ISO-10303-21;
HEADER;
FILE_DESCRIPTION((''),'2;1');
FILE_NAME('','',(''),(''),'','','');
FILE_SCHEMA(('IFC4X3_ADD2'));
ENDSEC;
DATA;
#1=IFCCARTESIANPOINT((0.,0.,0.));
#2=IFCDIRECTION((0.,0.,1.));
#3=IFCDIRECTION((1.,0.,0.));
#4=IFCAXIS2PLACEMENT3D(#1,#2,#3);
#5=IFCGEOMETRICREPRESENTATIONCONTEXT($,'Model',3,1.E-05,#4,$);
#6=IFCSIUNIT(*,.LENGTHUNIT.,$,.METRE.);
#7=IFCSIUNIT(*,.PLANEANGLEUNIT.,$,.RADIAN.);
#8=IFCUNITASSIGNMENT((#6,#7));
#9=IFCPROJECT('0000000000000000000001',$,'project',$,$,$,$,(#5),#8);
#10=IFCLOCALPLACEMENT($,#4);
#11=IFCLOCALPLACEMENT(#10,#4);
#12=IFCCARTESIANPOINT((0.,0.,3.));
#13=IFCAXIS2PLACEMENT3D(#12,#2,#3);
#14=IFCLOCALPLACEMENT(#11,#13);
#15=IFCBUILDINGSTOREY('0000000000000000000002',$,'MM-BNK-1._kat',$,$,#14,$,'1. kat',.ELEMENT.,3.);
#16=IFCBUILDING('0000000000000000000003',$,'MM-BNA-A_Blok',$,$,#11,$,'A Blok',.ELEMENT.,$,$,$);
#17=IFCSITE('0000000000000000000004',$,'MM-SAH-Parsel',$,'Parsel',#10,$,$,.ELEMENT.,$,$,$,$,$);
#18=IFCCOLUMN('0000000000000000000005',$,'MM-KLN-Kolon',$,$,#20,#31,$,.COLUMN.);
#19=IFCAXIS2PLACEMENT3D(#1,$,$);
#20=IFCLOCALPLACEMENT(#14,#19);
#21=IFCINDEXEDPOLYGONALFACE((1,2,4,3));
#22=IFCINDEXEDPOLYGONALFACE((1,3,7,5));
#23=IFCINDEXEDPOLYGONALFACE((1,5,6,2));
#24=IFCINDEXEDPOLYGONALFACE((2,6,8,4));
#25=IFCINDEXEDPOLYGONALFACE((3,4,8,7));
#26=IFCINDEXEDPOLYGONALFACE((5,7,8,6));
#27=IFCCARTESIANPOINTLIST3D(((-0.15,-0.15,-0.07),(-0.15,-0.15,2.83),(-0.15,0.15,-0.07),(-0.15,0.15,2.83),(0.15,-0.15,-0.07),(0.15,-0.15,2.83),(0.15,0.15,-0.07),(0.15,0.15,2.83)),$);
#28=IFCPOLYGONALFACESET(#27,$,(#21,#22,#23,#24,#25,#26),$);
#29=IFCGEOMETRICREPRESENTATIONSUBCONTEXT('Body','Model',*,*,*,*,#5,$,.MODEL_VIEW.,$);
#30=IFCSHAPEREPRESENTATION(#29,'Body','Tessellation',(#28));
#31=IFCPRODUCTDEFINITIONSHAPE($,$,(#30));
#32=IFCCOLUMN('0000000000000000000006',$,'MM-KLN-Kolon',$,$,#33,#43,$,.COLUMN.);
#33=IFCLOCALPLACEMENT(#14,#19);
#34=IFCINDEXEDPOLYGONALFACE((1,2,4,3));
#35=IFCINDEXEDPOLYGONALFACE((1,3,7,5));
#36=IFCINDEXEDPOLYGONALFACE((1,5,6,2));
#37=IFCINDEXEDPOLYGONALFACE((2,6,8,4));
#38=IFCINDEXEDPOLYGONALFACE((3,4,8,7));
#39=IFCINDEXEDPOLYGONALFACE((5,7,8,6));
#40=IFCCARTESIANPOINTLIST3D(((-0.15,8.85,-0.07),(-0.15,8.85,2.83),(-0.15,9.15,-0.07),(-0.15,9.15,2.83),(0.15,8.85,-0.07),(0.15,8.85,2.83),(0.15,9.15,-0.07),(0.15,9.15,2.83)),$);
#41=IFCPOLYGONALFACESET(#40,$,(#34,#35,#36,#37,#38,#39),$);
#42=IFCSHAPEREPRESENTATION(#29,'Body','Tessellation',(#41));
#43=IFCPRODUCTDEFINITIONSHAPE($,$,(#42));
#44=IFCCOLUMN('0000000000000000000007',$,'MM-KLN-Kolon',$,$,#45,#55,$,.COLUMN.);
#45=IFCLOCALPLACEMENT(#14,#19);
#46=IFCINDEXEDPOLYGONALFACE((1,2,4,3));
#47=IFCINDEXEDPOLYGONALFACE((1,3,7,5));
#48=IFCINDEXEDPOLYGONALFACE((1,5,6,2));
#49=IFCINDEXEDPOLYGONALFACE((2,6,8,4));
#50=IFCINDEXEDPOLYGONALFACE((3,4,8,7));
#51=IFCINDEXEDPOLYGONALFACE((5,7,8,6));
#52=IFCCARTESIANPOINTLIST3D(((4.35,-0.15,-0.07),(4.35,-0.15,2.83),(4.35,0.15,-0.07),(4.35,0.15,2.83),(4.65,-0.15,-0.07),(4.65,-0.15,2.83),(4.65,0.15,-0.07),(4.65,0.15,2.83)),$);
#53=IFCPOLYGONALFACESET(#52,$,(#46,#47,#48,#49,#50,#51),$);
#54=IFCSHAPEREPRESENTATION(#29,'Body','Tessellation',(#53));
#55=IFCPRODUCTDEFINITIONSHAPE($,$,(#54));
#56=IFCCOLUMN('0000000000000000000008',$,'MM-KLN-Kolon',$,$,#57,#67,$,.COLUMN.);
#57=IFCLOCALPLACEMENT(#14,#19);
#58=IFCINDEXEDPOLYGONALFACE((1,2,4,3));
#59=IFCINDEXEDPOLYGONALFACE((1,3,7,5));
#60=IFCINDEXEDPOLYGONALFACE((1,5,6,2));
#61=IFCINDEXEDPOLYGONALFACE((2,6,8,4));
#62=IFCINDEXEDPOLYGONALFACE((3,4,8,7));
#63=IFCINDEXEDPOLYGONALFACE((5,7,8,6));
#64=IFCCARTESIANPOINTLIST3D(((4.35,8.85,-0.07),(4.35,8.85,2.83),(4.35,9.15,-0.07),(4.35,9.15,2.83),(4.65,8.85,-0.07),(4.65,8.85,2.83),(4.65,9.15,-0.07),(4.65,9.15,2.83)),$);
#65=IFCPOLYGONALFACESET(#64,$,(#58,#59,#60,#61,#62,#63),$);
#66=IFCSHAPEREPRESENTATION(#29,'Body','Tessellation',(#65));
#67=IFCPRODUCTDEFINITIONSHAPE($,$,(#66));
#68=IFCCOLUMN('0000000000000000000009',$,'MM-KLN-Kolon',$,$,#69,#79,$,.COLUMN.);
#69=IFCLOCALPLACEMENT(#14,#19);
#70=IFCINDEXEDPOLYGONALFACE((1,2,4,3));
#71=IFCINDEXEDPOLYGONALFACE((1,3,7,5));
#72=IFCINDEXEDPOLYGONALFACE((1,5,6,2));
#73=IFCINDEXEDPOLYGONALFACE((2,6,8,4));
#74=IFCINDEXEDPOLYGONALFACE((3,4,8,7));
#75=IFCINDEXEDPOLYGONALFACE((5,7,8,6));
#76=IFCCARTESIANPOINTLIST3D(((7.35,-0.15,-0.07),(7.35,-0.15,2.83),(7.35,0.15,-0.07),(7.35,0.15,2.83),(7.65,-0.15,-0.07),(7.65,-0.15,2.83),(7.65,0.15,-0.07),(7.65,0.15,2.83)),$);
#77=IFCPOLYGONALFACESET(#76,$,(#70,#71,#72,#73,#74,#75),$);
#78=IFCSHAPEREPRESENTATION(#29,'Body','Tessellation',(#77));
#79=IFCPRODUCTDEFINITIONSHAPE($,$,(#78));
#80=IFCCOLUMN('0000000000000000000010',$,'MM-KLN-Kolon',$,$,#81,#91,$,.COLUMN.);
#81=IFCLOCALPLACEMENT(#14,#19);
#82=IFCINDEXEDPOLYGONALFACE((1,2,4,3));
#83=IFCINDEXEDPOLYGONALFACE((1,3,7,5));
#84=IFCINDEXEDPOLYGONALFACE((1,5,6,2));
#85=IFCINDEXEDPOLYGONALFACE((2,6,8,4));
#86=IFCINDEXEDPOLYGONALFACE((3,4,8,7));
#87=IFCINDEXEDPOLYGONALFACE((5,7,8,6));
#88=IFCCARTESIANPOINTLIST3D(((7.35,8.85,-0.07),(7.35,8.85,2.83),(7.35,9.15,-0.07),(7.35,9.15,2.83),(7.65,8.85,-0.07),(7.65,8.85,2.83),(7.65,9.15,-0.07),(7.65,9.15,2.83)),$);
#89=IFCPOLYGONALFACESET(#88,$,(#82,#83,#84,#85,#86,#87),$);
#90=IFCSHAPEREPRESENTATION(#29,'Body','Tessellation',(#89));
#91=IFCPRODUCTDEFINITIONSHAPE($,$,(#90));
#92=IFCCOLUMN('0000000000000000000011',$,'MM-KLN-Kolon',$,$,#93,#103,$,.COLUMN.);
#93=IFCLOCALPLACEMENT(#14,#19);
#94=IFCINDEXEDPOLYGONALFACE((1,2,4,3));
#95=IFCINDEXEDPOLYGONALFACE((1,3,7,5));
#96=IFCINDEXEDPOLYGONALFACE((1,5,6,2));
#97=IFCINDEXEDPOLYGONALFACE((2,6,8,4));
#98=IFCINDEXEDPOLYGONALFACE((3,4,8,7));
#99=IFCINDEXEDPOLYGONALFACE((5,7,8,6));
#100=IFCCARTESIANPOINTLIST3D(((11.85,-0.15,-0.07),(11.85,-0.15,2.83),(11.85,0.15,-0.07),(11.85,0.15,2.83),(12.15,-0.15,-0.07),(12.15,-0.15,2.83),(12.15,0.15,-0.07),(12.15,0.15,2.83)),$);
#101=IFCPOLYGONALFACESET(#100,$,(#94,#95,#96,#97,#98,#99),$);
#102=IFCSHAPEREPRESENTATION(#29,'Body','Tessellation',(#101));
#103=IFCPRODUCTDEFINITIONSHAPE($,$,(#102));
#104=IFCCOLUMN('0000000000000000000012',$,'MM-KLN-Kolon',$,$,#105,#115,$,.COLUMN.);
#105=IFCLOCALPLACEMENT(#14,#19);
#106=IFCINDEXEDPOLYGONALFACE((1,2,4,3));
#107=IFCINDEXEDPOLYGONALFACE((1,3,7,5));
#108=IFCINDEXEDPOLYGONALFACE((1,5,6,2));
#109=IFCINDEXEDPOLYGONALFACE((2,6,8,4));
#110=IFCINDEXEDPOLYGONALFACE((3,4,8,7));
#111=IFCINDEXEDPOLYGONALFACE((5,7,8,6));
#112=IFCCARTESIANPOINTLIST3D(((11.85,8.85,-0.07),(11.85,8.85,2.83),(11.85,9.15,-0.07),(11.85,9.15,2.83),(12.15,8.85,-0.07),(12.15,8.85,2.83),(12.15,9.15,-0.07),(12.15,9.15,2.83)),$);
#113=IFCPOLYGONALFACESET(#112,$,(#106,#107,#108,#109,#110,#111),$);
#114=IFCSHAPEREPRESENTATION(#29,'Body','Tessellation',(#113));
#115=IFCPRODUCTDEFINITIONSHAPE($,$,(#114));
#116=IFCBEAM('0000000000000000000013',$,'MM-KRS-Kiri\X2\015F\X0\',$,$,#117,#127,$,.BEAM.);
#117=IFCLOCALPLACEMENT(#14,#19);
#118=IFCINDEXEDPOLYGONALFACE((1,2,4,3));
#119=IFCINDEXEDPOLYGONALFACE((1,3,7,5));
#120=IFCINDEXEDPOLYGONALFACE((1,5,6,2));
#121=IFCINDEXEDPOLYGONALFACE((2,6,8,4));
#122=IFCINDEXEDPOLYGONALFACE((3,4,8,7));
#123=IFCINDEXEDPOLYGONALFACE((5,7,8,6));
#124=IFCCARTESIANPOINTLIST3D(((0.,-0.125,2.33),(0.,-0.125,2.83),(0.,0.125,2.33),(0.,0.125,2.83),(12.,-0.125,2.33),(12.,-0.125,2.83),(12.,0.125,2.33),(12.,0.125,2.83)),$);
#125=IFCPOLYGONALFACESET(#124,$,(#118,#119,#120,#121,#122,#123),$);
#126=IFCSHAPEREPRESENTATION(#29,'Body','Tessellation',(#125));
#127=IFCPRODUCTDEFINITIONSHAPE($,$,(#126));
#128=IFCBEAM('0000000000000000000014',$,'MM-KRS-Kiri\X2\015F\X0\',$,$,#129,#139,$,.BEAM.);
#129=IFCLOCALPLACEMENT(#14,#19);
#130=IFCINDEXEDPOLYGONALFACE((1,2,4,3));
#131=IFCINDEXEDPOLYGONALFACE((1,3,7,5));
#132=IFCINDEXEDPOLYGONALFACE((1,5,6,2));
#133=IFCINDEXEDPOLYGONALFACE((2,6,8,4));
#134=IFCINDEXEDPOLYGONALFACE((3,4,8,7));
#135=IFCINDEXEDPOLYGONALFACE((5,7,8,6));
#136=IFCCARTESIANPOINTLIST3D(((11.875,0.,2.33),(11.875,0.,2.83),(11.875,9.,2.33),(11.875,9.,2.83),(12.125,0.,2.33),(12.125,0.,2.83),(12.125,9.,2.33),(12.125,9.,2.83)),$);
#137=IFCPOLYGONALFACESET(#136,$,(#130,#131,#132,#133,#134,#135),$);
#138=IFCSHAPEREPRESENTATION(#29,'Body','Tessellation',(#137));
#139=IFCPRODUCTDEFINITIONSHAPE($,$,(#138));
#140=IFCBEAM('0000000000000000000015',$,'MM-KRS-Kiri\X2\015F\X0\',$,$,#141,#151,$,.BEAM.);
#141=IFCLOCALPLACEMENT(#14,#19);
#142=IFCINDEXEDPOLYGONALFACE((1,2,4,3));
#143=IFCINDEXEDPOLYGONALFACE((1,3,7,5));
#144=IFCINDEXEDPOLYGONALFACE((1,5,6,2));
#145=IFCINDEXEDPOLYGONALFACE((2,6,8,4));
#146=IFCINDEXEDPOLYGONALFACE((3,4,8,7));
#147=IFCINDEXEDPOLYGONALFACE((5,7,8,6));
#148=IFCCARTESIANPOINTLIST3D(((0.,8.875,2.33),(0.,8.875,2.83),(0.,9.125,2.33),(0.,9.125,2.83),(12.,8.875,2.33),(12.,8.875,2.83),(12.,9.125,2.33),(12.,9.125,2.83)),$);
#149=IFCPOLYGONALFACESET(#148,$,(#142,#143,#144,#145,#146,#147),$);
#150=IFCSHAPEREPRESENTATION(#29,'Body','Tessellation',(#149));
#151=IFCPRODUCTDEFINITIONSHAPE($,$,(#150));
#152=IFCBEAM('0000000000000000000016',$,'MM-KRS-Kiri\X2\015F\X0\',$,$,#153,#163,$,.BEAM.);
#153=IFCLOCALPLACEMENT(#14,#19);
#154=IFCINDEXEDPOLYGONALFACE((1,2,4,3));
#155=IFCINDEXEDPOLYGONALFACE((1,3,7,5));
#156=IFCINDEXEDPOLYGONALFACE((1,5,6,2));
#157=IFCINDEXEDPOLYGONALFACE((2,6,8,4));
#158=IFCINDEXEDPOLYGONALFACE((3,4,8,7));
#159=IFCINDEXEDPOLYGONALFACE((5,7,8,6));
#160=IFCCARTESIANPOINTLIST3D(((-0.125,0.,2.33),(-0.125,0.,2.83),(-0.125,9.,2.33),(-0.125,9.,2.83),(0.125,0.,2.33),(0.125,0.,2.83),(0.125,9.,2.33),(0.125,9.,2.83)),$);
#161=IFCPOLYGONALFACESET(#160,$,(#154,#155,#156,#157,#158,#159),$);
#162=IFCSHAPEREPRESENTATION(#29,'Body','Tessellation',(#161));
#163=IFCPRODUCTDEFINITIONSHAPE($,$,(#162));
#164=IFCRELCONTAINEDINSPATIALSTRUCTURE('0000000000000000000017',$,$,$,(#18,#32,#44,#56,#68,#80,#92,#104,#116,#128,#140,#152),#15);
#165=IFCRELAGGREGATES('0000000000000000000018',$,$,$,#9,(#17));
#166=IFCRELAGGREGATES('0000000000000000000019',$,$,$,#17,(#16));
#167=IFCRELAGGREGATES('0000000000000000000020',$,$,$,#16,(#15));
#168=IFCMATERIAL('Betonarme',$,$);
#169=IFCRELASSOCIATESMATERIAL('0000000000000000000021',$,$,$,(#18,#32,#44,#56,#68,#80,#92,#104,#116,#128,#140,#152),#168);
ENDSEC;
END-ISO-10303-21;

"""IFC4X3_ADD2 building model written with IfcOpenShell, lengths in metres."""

from ifc_helpers import new_model, si_unit, frame, origin_with_axes, place, context, subcontext, project, spatial, polyline, outline, extrude, material, element, save


model = new_model("IFC4X3_ADD2")

# Units and contexts
model_context = context("Model", 3, precision=1e-05, world=origin_with_axes())
body_context = subcontext(model_context, "Body", "Model", "MODEL_VIEW")
ifc_project = project(units=[si_unit("LENGTHUNIT", "METRE"), si_unit("PLANEANGLEUNIT", "RADIAN")], contexts=[model_context])

# Site, building, storey
site_placement = place(None, origin_with_axes())
site = spatial("IfcSite", under=ifc_project, at=site_placement, Name="MM-SAH-Parsel", ObjectType="Parsel", CompositionType="ELEMENT")
building_placement = place(site_placement, origin_with_axes())
building = spatial("IfcBuilding", under=site, at=building_placement, Name="MM-BNA-A_Blok", LongName="A Blok", CompositionType="ELEMENT")
storey_placement = place(building_placement, frame((0.0, 0.0, 3.0), z_axis=(0.0, 0.0, 1.0), x_axis=(1.0, 0.0, 0.0)))
storey = spatial("IfcBuildingStorey", under=building, at=storey_placement, Name="MM-BNK-1._kat", LongName="1. kat", CompositionType="ELEMENT", Elevation=3.0)

# Columns
ifc_material_1 = material(Name="Betonarme")
column_1_placement = place(storey_placement, origin_with_axes())
element("IfcColumn", 1, at=column_1_placement, inside=storey, material=ifc_material_1, Name="MM-KLN-Kolon", PredefinedType="COLUMN", context=body_context, shape_type="SweptSolid", body=[
    extrude(outline(polyline([(-0.15, -0.15), (0.15, -0.15), (0.15, 0.15), (-0.15, 0.15), (-0.15, -0.15)])), frame((0.0, 0.0, -0.07)), (0.0, 0.0, 1.0), 2.9),
])
column_2_placement = place(storey_placement, origin_with_axes())
element("IfcColumn", 2, at=column_2_placement, inside=storey, material=ifc_material_1, Name="MM-KLN-Kolon", PredefinedType="COLUMN", context=body_context, shape_type="SweptSolid", body=[
    extrude(outline(polyline([(-0.15, 8.85), (0.15, 8.85), (0.15, 9.15), (-0.15, 9.15), (-0.15, 8.85)])), frame((0.0, 0.0, -0.07)), (0.0, 0.0, 1.0), 2.9),
])
column_3_placement = place(storey_placement, origin_with_axes())
element("IfcColumn", 3, at=column_3_placement, inside=storey, material=ifc_material_1, Name="MM-KLN-Kolon", PredefinedType="COLUMN", context=body_context, shape_type="SweptSolid", body=[
    extrude(outline(polyline([(4.35, -0.15), (4.65, -0.15), (4.65, 0.15), (4.35, 0.15), (4.35, -0.15)])), frame((0.0, 0.0, -0.07)), (0.0, 0.0, 1.0), 2.9),
])
column_4_placement = place(storey_placement, origin_with_axes())
element("IfcColumn", 4, at=column_4_placement, inside=storey, material=ifc_material_1, Name="MM-KLN-Kolon", PredefinedType="COLUMN", context=body_context, shape_type="SweptSolid", body=[
    extrude(outline(polyline([(4.35, 8.85), (4.65, 8.85), (4.65, 9.15), (4.35, 9.15), (4.35, 8.85)])), frame((0.0, 0.0, -0.07)), (0.0, 0.0, 1.0), 2.9),
])
column_5_placement = place(storey_placement, origin_with_axes())
element("IfcColumn", 5, at=column_5_placement, inside=storey, material=ifc_material_1, Name="MM-KLN-Kolon", PredefinedType="COLUMN", context=body_context, shape_type="SweptSolid", body=[
    extrude(outline(polyline([(7.35, -0.15), (7.65, -0.15), (7.65, 0.15), (7.35, 0.15), (7.35, -0.15)])), frame((0.0, 0.0, -0.07)), (0.0, 0.0, 1.0), 2.9),
])
column_6_placement = place(storey_placement, origin_with_axes())
element("IfcColumn", 6, at=column_6_placement, inside=storey, material=ifc_material_1, Name="MM-KLN-Kolon", PredefinedType="COLUMN", context=body_context, shape_type="SweptSolid", body=[
    extrude(outline(polyline([(7.35, 8.85), (7.65, 8.85), (7.65, 9.15), (7.35, 9.15), (7.35, 8.85)])), frame((0.0, 0.0, -0.07)), (0.0, 0.0, 1.0), 2.9),
])
column_7_placement = place(storey_placement, origin_with_axes())
element("IfcColumn", 7, at=column_7_placement, inside=storey, material=ifc_material_1, Name="MM-KLN-Kolon", PredefinedType="COLUMN", context=body_context, shape_type="SweptSolid", body=[
    extrude(outline(polyline([(11.85, -0.15), (12.15, -0.15), (12.15, 0.15), (11.85, 0.15), (11.85, -0.15)])), frame((0.0, 0.0, -0.07)), (0.0, 0.0, 1.0), 2.9),
])
column_8_placement = place(storey_placement, origin_with_axes())
element("IfcColumn", 8, at=column_8_placement, inside=storey, material=ifc_material_1, Name="MM-KLN-Kolon", PredefinedType="COLUMN", context=body_context, shape_type="SweptSolid", body=[
    extrude(outline(polyline([(11.85, 8.85), (12.15, 8.85), (12.15, 9.15), (11.85, 9.15), (11.85, 8.85)])), frame((0.0, 0.0, -0.07)), (0.0, 0.0, 1.0), 2.9),
])

# Beams
beam_1_placement = place(storey_placement, origin_with_axes())
element("IfcBeam", 9, at=beam_1_placement, inside=storey, material=ifc_material_1, Name="MM-KRS-Kiriş", PredefinedType="BEAM", context=body_context, shape_type="SweptSolid", body=[
    extrude(outline(polyline([(0.0, 0.125), (12.0, 0.125), (12.0, -0.125), (0.0, -0.125), (0.0, 0.125)])), frame((0.0, 0.0, 2.33)), (0.0, 0.0, 1.0), 0.5),
])
beam_2_placement = place(storey_placement, origin_with_axes())
element("IfcBeam", 10, at=beam_2_placement, inside=storey, material=ifc_material_1, Name="MM-KRS-Kiriş", PredefinedType="BEAM", context=body_context, shape_type="SweptSolid", body=[
    extrude(outline(polyline([(11.875, 0.0), (11.875, 9.0), (12.125, 9.0), (12.125, 0.0), (11.875, 0.0)])), frame((0.0, 0.0, 2.33)), (0.0, 0.0, 1.0), 0.5),
])
beam_3_placement = place(storey_placement, origin_with_axes())
element("IfcBeam", 11, at=beam_3_placement, inside=storey, material=ifc_material_1, Name="MM-KRS-Kiriş", PredefinedType="BEAM", context=body_context, shape_type="SweptSolid", body=[
    extrude(outline(polyline([(12.0, 8.875), (0.0, 8.875), (0.0, 9.125), (12.0, 9.125), (12.0, 8.875)])), frame((0.0, 0.0, 2.33)), (0.0, 0.0, 1.0), 0.5),
])
beam_4_placement = place(storey_placement, origin_with_axes())
element("IfcBeam", 12, at=beam_4_placement, inside=storey, material=ifc_material_1, Name="MM-KRS-Kiriş", PredefinedType="BEAM", context=body_context, shape_type="SweptSolid", body=[
    extrude(outline(polyline([(0.125, 9.0), (0.125, 0.0), (-0.125, 0.0), (-0.125, 9.0), (0.125, 9.0)])), frame((0.0, 0.0, 2.33)), (0.0, 0.0, 1.0), 0.5),
])

save(model, "model.ifc")
